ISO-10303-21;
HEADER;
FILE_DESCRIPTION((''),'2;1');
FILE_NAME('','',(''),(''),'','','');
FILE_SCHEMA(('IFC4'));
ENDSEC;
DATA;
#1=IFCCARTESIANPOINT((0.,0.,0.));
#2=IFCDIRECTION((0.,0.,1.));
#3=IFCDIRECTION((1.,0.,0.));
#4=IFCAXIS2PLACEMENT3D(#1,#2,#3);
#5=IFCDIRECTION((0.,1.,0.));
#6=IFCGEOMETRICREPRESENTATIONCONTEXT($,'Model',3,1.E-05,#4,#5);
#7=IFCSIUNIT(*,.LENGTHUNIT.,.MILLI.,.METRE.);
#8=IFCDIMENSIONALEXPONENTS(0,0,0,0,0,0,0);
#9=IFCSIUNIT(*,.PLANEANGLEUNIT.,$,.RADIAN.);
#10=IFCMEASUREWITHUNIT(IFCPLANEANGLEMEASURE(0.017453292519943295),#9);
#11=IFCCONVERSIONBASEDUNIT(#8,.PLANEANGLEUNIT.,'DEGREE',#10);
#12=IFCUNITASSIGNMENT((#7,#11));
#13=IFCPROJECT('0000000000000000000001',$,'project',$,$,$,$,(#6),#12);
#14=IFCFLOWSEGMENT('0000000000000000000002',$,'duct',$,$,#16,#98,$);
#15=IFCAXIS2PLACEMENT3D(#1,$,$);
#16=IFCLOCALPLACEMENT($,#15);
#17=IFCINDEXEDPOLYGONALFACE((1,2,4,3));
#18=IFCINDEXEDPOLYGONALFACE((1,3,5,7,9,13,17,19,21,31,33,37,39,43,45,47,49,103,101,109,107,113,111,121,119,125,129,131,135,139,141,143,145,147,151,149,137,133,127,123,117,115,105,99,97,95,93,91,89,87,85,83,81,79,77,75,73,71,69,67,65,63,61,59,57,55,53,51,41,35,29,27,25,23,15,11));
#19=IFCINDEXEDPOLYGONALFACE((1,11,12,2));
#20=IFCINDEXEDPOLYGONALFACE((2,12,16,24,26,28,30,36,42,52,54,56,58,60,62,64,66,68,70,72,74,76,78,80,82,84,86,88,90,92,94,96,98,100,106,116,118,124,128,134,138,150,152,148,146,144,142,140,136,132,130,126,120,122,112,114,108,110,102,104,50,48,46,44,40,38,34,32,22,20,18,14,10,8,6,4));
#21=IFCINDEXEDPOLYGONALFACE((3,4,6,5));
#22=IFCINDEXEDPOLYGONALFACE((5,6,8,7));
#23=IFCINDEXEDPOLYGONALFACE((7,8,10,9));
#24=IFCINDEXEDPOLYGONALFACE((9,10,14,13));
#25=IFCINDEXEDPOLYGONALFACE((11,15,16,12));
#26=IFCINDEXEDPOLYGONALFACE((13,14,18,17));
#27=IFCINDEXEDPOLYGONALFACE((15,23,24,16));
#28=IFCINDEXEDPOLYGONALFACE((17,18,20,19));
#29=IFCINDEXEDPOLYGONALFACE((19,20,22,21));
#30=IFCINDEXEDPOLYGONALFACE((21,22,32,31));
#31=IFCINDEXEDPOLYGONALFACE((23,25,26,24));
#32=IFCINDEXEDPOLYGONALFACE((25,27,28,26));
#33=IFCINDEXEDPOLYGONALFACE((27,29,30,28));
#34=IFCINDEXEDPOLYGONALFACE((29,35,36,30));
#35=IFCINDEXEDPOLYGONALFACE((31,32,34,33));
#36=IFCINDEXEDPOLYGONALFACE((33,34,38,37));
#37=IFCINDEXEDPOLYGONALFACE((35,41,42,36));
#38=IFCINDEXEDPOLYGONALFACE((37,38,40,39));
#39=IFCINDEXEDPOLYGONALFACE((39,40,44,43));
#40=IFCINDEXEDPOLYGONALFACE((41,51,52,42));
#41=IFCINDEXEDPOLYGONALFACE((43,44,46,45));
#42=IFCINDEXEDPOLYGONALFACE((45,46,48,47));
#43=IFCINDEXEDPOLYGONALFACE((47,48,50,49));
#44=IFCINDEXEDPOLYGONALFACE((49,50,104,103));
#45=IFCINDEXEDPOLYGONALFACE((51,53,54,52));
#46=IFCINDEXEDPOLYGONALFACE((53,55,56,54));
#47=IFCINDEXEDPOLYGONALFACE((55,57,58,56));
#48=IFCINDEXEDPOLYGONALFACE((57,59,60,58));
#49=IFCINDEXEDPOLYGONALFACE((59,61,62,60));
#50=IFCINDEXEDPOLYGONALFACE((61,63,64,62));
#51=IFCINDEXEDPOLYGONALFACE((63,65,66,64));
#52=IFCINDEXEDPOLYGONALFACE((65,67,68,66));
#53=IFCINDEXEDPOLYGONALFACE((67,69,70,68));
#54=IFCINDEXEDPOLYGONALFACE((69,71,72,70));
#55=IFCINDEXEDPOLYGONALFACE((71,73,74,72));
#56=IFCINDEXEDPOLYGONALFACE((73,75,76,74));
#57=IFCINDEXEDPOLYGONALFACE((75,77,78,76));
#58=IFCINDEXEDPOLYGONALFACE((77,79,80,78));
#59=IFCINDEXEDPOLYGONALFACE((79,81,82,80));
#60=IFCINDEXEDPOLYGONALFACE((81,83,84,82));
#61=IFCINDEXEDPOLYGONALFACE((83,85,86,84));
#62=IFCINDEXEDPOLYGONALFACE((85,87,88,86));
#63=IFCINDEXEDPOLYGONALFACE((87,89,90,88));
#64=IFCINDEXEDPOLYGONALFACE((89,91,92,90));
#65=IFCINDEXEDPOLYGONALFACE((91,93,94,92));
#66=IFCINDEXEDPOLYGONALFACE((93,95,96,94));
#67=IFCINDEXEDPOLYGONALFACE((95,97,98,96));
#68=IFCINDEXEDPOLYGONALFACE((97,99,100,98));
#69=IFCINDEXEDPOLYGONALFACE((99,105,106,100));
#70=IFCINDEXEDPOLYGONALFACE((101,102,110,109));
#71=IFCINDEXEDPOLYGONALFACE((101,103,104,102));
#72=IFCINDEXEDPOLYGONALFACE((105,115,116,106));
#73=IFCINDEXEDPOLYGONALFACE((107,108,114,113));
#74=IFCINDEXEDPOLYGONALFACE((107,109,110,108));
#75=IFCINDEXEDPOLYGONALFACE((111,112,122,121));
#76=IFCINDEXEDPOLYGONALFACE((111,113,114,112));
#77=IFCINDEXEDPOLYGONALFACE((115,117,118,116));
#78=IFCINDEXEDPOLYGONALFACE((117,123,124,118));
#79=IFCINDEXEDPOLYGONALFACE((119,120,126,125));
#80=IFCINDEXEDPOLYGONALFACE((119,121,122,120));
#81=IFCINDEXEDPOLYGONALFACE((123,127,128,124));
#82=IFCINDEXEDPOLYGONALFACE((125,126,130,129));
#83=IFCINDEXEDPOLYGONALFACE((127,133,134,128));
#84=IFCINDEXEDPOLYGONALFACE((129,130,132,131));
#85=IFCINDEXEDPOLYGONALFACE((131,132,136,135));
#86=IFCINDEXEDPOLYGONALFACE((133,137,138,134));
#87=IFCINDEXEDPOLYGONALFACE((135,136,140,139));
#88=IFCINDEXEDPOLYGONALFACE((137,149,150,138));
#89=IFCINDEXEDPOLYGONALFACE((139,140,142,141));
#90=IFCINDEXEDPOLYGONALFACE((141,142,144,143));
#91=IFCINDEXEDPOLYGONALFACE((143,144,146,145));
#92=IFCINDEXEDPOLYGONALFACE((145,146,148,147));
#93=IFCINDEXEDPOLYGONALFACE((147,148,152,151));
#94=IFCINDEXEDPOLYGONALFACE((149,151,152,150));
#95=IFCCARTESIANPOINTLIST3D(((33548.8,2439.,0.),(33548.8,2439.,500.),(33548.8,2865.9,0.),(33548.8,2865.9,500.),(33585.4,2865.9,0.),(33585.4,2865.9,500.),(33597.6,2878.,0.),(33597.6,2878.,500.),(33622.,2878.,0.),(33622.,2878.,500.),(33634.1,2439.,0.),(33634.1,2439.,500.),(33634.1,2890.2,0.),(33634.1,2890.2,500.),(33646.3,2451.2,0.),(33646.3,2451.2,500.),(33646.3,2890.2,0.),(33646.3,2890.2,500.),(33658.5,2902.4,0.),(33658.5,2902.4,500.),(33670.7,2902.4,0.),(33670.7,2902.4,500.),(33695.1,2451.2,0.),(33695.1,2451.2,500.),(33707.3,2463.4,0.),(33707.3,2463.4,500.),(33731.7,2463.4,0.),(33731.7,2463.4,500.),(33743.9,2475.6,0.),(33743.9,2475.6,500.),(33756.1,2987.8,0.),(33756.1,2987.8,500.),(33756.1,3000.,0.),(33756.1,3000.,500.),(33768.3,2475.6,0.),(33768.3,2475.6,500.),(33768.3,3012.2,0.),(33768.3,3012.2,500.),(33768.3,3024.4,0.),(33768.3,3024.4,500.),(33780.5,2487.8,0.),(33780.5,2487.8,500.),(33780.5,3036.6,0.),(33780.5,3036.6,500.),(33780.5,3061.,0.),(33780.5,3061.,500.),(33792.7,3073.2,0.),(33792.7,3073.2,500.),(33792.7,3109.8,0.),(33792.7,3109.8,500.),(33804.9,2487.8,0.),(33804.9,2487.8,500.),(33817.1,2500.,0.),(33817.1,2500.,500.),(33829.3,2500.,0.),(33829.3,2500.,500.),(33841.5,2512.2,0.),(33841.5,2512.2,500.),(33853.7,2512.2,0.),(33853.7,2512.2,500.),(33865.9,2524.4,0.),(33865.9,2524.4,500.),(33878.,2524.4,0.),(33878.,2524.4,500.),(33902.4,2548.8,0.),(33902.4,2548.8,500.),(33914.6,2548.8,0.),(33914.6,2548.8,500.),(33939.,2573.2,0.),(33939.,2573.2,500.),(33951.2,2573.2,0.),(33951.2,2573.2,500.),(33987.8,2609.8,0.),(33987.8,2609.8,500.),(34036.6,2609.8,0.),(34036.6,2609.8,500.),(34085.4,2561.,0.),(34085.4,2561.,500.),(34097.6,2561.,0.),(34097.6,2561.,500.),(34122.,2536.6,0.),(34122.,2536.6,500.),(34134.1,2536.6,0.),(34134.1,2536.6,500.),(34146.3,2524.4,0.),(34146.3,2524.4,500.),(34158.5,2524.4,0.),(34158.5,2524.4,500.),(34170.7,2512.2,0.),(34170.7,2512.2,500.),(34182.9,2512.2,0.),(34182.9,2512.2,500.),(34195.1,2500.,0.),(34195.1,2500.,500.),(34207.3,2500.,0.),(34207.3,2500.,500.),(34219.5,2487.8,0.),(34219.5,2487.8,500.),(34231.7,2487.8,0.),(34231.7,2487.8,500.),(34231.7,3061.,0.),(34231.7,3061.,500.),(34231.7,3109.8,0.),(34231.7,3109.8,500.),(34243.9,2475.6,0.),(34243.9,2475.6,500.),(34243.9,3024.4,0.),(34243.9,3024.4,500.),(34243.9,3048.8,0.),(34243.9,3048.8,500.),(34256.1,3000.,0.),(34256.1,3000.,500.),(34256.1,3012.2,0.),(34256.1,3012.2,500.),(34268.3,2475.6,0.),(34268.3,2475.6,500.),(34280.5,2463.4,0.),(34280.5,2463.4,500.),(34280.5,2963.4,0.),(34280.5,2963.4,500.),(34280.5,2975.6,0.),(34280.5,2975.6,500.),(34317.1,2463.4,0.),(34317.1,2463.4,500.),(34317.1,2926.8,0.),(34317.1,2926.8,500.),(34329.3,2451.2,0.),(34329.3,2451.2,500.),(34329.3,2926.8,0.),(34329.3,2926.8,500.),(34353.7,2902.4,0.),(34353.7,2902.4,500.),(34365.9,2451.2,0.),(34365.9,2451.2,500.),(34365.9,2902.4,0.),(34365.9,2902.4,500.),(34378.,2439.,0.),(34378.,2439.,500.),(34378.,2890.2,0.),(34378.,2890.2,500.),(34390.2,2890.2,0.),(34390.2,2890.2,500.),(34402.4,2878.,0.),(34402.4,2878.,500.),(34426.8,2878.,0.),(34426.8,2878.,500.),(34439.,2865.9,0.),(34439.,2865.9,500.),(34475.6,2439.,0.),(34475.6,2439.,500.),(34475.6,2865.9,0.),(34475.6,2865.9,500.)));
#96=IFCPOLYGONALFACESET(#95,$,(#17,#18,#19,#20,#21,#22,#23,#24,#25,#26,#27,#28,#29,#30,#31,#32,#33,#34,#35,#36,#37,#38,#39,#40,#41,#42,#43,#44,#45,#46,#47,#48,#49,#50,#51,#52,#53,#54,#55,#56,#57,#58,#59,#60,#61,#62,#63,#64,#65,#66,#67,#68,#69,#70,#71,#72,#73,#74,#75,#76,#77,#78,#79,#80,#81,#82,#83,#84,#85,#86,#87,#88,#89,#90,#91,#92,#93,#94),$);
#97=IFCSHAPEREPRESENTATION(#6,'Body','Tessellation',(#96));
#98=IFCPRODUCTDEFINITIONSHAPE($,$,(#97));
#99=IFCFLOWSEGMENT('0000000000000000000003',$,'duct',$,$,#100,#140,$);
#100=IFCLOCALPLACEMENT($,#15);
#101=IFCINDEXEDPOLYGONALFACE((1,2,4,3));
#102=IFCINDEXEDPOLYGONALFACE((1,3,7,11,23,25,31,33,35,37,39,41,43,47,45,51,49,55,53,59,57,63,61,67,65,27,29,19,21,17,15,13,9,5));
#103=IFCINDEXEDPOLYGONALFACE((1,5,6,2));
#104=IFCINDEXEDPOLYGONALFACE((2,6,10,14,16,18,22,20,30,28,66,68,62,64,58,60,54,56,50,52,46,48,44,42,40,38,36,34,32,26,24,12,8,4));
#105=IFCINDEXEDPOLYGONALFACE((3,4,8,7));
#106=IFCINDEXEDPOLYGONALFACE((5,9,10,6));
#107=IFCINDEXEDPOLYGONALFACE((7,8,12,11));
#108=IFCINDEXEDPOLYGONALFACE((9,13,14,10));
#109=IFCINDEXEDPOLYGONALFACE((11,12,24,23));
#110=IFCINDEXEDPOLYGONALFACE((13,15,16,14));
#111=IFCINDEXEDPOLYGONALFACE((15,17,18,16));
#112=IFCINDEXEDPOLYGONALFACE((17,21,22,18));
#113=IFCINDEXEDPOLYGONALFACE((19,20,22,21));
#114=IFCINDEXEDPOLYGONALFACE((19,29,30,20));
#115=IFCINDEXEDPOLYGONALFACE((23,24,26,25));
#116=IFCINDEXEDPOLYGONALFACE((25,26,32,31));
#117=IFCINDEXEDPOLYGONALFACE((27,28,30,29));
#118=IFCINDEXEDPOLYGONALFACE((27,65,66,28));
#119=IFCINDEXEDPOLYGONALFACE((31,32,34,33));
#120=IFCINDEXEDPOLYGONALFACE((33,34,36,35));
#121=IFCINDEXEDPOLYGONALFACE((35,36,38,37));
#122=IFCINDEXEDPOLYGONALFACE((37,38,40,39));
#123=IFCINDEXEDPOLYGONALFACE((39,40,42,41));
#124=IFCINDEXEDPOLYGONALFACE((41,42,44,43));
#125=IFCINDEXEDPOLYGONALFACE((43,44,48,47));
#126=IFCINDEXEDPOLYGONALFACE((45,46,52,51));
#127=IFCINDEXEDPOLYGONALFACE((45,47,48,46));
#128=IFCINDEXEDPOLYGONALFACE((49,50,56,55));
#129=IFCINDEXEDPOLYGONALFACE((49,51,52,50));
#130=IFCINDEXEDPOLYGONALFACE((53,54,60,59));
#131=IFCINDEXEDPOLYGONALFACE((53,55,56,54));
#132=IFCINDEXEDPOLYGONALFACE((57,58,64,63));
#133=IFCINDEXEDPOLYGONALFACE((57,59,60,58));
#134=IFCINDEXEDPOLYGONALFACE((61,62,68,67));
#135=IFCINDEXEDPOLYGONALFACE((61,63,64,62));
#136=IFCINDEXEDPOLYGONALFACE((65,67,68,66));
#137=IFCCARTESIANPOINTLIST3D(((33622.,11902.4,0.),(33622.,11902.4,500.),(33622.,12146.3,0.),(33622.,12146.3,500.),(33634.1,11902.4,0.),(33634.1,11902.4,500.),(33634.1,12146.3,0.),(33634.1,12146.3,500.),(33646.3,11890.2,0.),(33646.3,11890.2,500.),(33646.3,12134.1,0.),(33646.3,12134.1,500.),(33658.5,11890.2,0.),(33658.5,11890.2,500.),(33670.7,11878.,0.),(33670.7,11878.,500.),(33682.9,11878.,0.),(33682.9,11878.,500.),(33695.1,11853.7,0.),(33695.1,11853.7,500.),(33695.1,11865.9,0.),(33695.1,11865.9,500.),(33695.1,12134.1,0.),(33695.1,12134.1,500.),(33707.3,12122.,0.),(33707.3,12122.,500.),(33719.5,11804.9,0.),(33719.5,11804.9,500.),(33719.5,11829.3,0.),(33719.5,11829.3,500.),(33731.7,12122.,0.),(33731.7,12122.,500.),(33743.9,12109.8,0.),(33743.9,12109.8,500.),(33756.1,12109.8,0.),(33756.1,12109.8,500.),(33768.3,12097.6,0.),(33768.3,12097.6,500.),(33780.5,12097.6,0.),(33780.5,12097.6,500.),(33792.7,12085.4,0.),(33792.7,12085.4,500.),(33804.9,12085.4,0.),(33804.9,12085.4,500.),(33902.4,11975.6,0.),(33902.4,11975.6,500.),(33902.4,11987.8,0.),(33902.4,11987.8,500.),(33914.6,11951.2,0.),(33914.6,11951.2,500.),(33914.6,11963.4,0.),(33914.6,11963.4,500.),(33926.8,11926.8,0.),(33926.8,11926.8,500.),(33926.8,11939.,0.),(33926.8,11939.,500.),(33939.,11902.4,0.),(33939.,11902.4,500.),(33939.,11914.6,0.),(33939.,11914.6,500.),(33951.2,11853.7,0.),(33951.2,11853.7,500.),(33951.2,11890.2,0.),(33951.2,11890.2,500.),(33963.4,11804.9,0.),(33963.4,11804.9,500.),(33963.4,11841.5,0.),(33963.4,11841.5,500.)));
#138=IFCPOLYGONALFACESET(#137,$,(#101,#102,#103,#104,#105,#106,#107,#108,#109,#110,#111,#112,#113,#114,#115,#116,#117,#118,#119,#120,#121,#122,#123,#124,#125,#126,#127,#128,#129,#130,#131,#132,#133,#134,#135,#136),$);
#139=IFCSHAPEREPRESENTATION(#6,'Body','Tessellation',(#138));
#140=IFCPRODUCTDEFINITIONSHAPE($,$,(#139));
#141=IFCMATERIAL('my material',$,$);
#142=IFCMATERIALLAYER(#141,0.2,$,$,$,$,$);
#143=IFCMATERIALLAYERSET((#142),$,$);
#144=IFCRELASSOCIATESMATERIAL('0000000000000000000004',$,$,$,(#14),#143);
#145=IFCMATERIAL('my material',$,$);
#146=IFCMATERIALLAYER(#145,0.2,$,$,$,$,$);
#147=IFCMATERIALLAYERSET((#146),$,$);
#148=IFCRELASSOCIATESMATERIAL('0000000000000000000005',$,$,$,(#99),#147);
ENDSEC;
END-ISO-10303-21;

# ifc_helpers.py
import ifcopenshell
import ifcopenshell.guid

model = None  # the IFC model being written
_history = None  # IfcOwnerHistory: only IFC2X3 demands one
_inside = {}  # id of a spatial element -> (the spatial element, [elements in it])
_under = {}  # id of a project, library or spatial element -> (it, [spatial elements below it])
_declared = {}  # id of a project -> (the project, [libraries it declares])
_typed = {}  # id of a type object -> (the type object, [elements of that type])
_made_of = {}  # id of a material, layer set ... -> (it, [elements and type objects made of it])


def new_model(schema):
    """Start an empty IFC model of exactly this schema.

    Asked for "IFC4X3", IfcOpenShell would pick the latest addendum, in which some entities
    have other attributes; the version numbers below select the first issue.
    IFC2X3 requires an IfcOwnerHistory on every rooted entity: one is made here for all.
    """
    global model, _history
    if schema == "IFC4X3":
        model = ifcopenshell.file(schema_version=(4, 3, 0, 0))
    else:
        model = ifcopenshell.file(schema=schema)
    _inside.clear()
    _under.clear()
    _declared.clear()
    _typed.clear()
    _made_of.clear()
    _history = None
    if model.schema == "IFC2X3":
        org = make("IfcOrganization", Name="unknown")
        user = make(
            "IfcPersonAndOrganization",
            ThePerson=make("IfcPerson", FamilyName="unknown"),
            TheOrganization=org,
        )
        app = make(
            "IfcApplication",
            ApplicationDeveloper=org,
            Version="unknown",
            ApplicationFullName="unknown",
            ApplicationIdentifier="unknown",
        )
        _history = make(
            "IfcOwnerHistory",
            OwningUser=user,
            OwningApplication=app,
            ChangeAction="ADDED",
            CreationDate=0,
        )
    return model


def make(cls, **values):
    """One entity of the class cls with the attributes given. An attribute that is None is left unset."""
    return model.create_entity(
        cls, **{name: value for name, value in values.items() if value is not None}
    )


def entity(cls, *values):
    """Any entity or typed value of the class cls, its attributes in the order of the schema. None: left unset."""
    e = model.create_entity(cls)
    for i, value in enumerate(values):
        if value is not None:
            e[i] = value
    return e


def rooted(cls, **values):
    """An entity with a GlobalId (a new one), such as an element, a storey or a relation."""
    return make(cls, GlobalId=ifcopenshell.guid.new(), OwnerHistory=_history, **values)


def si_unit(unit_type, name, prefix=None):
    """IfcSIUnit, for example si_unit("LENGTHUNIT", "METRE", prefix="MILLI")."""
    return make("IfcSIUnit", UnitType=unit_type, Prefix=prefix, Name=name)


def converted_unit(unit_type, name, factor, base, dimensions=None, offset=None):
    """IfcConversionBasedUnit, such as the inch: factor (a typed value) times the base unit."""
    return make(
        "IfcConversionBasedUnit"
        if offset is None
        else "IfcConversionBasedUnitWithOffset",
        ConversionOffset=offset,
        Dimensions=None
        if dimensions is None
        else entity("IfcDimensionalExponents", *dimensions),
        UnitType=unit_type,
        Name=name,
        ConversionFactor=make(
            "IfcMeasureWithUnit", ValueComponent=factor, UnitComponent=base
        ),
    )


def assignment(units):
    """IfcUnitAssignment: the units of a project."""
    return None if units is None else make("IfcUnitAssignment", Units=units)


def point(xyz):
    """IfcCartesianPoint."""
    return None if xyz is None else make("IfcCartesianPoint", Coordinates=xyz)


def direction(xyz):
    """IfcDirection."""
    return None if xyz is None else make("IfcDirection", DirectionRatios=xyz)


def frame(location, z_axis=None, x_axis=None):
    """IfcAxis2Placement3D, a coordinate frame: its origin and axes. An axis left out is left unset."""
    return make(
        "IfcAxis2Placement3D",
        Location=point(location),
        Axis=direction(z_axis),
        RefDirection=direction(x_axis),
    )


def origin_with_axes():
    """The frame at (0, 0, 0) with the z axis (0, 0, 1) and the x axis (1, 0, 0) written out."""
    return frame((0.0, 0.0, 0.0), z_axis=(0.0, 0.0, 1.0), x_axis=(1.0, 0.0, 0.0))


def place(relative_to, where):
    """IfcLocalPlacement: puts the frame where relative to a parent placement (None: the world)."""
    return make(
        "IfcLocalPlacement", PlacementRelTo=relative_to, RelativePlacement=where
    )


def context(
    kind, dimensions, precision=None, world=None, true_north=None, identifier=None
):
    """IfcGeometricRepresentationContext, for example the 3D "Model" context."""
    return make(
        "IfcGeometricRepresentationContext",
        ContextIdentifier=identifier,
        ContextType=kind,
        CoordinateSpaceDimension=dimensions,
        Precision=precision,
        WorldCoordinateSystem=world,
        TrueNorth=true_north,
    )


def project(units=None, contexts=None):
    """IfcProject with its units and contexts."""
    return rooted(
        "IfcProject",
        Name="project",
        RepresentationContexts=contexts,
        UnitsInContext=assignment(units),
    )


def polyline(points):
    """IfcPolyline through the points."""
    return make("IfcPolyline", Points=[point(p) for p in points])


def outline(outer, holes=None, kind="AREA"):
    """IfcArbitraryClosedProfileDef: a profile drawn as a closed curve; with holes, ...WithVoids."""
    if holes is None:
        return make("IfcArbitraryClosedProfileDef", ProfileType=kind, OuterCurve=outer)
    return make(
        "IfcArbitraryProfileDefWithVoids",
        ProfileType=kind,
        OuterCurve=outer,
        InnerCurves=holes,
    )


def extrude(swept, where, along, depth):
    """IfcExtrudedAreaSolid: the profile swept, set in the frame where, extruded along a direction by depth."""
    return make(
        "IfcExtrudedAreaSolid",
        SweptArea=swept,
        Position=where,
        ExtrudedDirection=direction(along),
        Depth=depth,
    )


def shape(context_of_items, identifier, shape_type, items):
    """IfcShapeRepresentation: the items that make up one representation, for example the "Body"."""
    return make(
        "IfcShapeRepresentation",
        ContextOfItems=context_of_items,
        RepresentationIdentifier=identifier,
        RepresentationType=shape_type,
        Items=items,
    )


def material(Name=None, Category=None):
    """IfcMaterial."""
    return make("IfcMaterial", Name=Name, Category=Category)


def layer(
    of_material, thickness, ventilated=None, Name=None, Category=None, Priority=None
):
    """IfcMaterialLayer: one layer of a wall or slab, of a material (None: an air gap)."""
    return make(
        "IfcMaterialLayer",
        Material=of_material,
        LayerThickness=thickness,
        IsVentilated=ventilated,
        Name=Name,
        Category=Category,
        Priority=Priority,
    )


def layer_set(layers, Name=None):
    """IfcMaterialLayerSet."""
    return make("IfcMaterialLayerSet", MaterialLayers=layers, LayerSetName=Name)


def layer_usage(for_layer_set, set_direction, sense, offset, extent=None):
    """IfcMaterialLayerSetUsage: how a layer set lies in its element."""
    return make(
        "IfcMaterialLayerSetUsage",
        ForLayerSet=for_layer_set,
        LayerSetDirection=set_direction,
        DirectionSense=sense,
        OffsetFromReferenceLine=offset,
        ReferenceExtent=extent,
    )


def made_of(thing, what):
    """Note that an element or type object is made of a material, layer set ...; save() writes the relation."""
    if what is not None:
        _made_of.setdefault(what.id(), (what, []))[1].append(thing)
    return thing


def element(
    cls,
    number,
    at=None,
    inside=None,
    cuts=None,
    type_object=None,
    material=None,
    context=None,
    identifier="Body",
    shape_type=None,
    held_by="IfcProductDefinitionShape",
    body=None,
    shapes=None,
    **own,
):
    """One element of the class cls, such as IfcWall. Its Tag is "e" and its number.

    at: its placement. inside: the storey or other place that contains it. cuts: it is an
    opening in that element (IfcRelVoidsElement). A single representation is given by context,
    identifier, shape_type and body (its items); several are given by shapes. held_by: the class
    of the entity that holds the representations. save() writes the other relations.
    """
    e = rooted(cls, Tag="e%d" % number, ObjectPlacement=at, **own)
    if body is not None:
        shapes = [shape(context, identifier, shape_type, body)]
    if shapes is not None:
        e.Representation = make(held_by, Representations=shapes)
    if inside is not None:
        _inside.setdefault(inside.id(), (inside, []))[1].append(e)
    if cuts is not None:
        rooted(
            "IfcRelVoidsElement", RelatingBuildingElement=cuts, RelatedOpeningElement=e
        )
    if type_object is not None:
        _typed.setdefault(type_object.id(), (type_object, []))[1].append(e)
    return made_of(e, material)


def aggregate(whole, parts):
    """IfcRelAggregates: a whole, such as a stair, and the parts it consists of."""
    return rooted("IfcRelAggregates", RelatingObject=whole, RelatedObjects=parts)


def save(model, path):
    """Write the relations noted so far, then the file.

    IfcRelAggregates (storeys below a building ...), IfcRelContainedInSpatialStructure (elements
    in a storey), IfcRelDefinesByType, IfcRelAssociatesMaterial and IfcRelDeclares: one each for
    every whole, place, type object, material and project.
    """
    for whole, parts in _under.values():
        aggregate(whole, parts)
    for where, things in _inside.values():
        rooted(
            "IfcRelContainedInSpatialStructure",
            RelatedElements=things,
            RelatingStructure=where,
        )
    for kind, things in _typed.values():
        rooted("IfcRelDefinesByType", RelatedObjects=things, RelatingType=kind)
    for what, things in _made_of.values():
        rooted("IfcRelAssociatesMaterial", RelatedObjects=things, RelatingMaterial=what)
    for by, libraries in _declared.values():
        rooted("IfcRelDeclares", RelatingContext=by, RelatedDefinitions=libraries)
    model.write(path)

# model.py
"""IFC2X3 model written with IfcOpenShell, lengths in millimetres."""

from ifc_helpers import new_model, entity, si_unit, converted_unit, direction, origin_with_axes, place, context, project, polyline, outline, extrude, material, layer, layer_set, layer_usage, element, save


model = new_model("IFC2X3")

# Units and contexts
model_context = context("Model", 3, precision=1e-05, world=origin_with_axes(), true_north=direction((0.0, 1.0, 0.0)))
ifc_project = project(units=[si_unit("LENGTHUNIT", "METRE", prefix="MILLI"), converted_unit("PLANEANGLEUNIT", "DEGREE", entity("IfcPlaneAngleMeasure", 0.017453292519943295), si_unit("PLANEANGLEUNIT", "RADIAN"), dimensions=[0, 0, 0, 0, 0, 0, 0])], contexts=[model_context])

# Flow segments
ifc_material_1 = material(Name="my material")
ifc_layer_1 = layer(ifc_material_1, 0.2)
ifc_layer_set_1 = layer_set([ifc_layer_1])
ifc_layer_usage_1 = layer_usage(ifc_layer_set_1, "AXIS2", "POSITIVE", -0.1)
flow_segment_1_placement = place(None, origin_with_axes())
element("IfcFlowSegment", 1, at=flow_segment_1_placement, material=ifc_layer_usage_1, Name="duct", context=model_context, shape_type="SweptSolid", body=[
    extrude(outline(polyline([(33548.8, 2439.0), (33634.1, 2439.0), (33646.3, 2451.2), (33695.1, 2451.2), (33707.3, 2463.4), (33731.7, 2463.4), (33743.9, 2475.6), (33768.3, 2475.6), (33780.5, 2487.8), (33804.9, 2487.8), (33817.1, 2500.0), (33829.3, 2500.0), (33841.5, 2512.2), (33853.7, 2512.2), (33865.9, 2524.4), (33878.0, 2524.4), (33902.4, 2548.8), (33914.6, 2548.8), (33939.0, 2573.2), (33951.2, 2573.2), (33987.8, 2609.8), (34036.6, 2609.8), (34085.4, 2561.0), (34097.6, 2561.0), (34122.0, 2536.6), (34134.1, 2536.6), (34146.3, 2524.4), (34158.5, 2524.4), (34170.7, 2512.2), (34182.9, 2512.2), (34195.1, 2500.0), (34207.3, 2500.0), (34219.5, 2487.8), (34231.7, 2487.8), (34243.9, 2475.6), (34268.3, 2475.6), (34280.5, 2463.4), (34317.1, 2463.4), (34329.3, 2451.2), (34365.9, 2451.2), (34378.0, 2439.0), (34475.6, 2439.0), (34475.6, 2865.9), (34439.0, 2865.9), (34426.8, 2878.0), (34402.4, 2878.0), (34390.2, 2890.2), (34378.0, 2890.2), (34365.9, 2902.4), (34353.7, 2902.4), (34329.3, 2926.8), (34317.1, 2926.8), (34280.5, 2963.4), (34280.5, 2975.6), (34256.1, 3000.0), (34256.1, 3012.2), (34243.9, 3024.4), (34243.9, 3048.8), (34231.7, 3061.0), (34231.7, 3109.8), (33792.7, 3109.8), (33792.7, 3073.2), (33780.5, 3061.0), (33780.5, 3036.6), (33768.3, 3024.4), (33768.3, 3012.2), (33756.1, 3000.0), (33756.1, 2987.8), (33670.7, 2902.4), (33658.5, 2902.4), (33646.3, 2890.2), (33634.1, 2890.2), (33622.0, 2878.0), (33597.6, 2878.0), (33585.4, 2865.9), (33548.8, 2865.9), (33548.8, 2439.0)])), origin_with_axes(), (0.0, 0.0, 1.0), 500.0),
])
ifc_material_2 = material(Name="my material")
ifc_layer_2 = layer(ifc_material_2, 0.2)
ifc_layer_set_2 = layer_set([ifc_layer_2])
ifc_layer_usage_2 = layer_usage(ifc_layer_set_2, "AXIS2", "POSITIVE", -0.1)
flow_segment_2_placement = place(None, origin_with_axes())
element("IfcFlowSegment", 2, at=flow_segment_2_placement, material=ifc_layer_usage_2, Name="duct", context=model_context, shape_type="SweptSolid", body=[
    extrude(outline(polyline([(33622.0, 11902.4), (33634.1, 11902.4), (33646.3, 11890.2), (33658.5, 11890.2), (33670.7, 11878.0), (33682.9, 11878.0), (33695.1, 11865.9), (33695.1, 11853.7), (33719.5, 11829.3), (33719.5, 11804.9), (33963.4, 11804.9), (33963.4, 11841.5), (33951.2, 11853.7), (33951.2, 11890.2), (33939.0, 11902.4), (33939.0, 11914.6), (33926.8, 11926.8), (33926.8, 11939.0), (33914.6, 11951.2), (33914.6, 11963.4), (33902.4, 11975.6), (33902.4, 11987.8), (33804.9, 12085.4), (33792.7, 12085.4), (33780.5, 12097.6), (33768.3, 12097.6), (33756.1, 12109.8), (33743.9, 12109.8), (33731.7, 12122.0), (33707.3, 12122.0), (33695.1, 12134.1), (33646.3, 12134.1), (33634.1, 12146.3), (33622.0, 12146.3), (33622.0, 11902.4)])), origin_with_axes(), (0.0, 0.0, 1.0), 500.0),
])

save(model, "model.ifc")
